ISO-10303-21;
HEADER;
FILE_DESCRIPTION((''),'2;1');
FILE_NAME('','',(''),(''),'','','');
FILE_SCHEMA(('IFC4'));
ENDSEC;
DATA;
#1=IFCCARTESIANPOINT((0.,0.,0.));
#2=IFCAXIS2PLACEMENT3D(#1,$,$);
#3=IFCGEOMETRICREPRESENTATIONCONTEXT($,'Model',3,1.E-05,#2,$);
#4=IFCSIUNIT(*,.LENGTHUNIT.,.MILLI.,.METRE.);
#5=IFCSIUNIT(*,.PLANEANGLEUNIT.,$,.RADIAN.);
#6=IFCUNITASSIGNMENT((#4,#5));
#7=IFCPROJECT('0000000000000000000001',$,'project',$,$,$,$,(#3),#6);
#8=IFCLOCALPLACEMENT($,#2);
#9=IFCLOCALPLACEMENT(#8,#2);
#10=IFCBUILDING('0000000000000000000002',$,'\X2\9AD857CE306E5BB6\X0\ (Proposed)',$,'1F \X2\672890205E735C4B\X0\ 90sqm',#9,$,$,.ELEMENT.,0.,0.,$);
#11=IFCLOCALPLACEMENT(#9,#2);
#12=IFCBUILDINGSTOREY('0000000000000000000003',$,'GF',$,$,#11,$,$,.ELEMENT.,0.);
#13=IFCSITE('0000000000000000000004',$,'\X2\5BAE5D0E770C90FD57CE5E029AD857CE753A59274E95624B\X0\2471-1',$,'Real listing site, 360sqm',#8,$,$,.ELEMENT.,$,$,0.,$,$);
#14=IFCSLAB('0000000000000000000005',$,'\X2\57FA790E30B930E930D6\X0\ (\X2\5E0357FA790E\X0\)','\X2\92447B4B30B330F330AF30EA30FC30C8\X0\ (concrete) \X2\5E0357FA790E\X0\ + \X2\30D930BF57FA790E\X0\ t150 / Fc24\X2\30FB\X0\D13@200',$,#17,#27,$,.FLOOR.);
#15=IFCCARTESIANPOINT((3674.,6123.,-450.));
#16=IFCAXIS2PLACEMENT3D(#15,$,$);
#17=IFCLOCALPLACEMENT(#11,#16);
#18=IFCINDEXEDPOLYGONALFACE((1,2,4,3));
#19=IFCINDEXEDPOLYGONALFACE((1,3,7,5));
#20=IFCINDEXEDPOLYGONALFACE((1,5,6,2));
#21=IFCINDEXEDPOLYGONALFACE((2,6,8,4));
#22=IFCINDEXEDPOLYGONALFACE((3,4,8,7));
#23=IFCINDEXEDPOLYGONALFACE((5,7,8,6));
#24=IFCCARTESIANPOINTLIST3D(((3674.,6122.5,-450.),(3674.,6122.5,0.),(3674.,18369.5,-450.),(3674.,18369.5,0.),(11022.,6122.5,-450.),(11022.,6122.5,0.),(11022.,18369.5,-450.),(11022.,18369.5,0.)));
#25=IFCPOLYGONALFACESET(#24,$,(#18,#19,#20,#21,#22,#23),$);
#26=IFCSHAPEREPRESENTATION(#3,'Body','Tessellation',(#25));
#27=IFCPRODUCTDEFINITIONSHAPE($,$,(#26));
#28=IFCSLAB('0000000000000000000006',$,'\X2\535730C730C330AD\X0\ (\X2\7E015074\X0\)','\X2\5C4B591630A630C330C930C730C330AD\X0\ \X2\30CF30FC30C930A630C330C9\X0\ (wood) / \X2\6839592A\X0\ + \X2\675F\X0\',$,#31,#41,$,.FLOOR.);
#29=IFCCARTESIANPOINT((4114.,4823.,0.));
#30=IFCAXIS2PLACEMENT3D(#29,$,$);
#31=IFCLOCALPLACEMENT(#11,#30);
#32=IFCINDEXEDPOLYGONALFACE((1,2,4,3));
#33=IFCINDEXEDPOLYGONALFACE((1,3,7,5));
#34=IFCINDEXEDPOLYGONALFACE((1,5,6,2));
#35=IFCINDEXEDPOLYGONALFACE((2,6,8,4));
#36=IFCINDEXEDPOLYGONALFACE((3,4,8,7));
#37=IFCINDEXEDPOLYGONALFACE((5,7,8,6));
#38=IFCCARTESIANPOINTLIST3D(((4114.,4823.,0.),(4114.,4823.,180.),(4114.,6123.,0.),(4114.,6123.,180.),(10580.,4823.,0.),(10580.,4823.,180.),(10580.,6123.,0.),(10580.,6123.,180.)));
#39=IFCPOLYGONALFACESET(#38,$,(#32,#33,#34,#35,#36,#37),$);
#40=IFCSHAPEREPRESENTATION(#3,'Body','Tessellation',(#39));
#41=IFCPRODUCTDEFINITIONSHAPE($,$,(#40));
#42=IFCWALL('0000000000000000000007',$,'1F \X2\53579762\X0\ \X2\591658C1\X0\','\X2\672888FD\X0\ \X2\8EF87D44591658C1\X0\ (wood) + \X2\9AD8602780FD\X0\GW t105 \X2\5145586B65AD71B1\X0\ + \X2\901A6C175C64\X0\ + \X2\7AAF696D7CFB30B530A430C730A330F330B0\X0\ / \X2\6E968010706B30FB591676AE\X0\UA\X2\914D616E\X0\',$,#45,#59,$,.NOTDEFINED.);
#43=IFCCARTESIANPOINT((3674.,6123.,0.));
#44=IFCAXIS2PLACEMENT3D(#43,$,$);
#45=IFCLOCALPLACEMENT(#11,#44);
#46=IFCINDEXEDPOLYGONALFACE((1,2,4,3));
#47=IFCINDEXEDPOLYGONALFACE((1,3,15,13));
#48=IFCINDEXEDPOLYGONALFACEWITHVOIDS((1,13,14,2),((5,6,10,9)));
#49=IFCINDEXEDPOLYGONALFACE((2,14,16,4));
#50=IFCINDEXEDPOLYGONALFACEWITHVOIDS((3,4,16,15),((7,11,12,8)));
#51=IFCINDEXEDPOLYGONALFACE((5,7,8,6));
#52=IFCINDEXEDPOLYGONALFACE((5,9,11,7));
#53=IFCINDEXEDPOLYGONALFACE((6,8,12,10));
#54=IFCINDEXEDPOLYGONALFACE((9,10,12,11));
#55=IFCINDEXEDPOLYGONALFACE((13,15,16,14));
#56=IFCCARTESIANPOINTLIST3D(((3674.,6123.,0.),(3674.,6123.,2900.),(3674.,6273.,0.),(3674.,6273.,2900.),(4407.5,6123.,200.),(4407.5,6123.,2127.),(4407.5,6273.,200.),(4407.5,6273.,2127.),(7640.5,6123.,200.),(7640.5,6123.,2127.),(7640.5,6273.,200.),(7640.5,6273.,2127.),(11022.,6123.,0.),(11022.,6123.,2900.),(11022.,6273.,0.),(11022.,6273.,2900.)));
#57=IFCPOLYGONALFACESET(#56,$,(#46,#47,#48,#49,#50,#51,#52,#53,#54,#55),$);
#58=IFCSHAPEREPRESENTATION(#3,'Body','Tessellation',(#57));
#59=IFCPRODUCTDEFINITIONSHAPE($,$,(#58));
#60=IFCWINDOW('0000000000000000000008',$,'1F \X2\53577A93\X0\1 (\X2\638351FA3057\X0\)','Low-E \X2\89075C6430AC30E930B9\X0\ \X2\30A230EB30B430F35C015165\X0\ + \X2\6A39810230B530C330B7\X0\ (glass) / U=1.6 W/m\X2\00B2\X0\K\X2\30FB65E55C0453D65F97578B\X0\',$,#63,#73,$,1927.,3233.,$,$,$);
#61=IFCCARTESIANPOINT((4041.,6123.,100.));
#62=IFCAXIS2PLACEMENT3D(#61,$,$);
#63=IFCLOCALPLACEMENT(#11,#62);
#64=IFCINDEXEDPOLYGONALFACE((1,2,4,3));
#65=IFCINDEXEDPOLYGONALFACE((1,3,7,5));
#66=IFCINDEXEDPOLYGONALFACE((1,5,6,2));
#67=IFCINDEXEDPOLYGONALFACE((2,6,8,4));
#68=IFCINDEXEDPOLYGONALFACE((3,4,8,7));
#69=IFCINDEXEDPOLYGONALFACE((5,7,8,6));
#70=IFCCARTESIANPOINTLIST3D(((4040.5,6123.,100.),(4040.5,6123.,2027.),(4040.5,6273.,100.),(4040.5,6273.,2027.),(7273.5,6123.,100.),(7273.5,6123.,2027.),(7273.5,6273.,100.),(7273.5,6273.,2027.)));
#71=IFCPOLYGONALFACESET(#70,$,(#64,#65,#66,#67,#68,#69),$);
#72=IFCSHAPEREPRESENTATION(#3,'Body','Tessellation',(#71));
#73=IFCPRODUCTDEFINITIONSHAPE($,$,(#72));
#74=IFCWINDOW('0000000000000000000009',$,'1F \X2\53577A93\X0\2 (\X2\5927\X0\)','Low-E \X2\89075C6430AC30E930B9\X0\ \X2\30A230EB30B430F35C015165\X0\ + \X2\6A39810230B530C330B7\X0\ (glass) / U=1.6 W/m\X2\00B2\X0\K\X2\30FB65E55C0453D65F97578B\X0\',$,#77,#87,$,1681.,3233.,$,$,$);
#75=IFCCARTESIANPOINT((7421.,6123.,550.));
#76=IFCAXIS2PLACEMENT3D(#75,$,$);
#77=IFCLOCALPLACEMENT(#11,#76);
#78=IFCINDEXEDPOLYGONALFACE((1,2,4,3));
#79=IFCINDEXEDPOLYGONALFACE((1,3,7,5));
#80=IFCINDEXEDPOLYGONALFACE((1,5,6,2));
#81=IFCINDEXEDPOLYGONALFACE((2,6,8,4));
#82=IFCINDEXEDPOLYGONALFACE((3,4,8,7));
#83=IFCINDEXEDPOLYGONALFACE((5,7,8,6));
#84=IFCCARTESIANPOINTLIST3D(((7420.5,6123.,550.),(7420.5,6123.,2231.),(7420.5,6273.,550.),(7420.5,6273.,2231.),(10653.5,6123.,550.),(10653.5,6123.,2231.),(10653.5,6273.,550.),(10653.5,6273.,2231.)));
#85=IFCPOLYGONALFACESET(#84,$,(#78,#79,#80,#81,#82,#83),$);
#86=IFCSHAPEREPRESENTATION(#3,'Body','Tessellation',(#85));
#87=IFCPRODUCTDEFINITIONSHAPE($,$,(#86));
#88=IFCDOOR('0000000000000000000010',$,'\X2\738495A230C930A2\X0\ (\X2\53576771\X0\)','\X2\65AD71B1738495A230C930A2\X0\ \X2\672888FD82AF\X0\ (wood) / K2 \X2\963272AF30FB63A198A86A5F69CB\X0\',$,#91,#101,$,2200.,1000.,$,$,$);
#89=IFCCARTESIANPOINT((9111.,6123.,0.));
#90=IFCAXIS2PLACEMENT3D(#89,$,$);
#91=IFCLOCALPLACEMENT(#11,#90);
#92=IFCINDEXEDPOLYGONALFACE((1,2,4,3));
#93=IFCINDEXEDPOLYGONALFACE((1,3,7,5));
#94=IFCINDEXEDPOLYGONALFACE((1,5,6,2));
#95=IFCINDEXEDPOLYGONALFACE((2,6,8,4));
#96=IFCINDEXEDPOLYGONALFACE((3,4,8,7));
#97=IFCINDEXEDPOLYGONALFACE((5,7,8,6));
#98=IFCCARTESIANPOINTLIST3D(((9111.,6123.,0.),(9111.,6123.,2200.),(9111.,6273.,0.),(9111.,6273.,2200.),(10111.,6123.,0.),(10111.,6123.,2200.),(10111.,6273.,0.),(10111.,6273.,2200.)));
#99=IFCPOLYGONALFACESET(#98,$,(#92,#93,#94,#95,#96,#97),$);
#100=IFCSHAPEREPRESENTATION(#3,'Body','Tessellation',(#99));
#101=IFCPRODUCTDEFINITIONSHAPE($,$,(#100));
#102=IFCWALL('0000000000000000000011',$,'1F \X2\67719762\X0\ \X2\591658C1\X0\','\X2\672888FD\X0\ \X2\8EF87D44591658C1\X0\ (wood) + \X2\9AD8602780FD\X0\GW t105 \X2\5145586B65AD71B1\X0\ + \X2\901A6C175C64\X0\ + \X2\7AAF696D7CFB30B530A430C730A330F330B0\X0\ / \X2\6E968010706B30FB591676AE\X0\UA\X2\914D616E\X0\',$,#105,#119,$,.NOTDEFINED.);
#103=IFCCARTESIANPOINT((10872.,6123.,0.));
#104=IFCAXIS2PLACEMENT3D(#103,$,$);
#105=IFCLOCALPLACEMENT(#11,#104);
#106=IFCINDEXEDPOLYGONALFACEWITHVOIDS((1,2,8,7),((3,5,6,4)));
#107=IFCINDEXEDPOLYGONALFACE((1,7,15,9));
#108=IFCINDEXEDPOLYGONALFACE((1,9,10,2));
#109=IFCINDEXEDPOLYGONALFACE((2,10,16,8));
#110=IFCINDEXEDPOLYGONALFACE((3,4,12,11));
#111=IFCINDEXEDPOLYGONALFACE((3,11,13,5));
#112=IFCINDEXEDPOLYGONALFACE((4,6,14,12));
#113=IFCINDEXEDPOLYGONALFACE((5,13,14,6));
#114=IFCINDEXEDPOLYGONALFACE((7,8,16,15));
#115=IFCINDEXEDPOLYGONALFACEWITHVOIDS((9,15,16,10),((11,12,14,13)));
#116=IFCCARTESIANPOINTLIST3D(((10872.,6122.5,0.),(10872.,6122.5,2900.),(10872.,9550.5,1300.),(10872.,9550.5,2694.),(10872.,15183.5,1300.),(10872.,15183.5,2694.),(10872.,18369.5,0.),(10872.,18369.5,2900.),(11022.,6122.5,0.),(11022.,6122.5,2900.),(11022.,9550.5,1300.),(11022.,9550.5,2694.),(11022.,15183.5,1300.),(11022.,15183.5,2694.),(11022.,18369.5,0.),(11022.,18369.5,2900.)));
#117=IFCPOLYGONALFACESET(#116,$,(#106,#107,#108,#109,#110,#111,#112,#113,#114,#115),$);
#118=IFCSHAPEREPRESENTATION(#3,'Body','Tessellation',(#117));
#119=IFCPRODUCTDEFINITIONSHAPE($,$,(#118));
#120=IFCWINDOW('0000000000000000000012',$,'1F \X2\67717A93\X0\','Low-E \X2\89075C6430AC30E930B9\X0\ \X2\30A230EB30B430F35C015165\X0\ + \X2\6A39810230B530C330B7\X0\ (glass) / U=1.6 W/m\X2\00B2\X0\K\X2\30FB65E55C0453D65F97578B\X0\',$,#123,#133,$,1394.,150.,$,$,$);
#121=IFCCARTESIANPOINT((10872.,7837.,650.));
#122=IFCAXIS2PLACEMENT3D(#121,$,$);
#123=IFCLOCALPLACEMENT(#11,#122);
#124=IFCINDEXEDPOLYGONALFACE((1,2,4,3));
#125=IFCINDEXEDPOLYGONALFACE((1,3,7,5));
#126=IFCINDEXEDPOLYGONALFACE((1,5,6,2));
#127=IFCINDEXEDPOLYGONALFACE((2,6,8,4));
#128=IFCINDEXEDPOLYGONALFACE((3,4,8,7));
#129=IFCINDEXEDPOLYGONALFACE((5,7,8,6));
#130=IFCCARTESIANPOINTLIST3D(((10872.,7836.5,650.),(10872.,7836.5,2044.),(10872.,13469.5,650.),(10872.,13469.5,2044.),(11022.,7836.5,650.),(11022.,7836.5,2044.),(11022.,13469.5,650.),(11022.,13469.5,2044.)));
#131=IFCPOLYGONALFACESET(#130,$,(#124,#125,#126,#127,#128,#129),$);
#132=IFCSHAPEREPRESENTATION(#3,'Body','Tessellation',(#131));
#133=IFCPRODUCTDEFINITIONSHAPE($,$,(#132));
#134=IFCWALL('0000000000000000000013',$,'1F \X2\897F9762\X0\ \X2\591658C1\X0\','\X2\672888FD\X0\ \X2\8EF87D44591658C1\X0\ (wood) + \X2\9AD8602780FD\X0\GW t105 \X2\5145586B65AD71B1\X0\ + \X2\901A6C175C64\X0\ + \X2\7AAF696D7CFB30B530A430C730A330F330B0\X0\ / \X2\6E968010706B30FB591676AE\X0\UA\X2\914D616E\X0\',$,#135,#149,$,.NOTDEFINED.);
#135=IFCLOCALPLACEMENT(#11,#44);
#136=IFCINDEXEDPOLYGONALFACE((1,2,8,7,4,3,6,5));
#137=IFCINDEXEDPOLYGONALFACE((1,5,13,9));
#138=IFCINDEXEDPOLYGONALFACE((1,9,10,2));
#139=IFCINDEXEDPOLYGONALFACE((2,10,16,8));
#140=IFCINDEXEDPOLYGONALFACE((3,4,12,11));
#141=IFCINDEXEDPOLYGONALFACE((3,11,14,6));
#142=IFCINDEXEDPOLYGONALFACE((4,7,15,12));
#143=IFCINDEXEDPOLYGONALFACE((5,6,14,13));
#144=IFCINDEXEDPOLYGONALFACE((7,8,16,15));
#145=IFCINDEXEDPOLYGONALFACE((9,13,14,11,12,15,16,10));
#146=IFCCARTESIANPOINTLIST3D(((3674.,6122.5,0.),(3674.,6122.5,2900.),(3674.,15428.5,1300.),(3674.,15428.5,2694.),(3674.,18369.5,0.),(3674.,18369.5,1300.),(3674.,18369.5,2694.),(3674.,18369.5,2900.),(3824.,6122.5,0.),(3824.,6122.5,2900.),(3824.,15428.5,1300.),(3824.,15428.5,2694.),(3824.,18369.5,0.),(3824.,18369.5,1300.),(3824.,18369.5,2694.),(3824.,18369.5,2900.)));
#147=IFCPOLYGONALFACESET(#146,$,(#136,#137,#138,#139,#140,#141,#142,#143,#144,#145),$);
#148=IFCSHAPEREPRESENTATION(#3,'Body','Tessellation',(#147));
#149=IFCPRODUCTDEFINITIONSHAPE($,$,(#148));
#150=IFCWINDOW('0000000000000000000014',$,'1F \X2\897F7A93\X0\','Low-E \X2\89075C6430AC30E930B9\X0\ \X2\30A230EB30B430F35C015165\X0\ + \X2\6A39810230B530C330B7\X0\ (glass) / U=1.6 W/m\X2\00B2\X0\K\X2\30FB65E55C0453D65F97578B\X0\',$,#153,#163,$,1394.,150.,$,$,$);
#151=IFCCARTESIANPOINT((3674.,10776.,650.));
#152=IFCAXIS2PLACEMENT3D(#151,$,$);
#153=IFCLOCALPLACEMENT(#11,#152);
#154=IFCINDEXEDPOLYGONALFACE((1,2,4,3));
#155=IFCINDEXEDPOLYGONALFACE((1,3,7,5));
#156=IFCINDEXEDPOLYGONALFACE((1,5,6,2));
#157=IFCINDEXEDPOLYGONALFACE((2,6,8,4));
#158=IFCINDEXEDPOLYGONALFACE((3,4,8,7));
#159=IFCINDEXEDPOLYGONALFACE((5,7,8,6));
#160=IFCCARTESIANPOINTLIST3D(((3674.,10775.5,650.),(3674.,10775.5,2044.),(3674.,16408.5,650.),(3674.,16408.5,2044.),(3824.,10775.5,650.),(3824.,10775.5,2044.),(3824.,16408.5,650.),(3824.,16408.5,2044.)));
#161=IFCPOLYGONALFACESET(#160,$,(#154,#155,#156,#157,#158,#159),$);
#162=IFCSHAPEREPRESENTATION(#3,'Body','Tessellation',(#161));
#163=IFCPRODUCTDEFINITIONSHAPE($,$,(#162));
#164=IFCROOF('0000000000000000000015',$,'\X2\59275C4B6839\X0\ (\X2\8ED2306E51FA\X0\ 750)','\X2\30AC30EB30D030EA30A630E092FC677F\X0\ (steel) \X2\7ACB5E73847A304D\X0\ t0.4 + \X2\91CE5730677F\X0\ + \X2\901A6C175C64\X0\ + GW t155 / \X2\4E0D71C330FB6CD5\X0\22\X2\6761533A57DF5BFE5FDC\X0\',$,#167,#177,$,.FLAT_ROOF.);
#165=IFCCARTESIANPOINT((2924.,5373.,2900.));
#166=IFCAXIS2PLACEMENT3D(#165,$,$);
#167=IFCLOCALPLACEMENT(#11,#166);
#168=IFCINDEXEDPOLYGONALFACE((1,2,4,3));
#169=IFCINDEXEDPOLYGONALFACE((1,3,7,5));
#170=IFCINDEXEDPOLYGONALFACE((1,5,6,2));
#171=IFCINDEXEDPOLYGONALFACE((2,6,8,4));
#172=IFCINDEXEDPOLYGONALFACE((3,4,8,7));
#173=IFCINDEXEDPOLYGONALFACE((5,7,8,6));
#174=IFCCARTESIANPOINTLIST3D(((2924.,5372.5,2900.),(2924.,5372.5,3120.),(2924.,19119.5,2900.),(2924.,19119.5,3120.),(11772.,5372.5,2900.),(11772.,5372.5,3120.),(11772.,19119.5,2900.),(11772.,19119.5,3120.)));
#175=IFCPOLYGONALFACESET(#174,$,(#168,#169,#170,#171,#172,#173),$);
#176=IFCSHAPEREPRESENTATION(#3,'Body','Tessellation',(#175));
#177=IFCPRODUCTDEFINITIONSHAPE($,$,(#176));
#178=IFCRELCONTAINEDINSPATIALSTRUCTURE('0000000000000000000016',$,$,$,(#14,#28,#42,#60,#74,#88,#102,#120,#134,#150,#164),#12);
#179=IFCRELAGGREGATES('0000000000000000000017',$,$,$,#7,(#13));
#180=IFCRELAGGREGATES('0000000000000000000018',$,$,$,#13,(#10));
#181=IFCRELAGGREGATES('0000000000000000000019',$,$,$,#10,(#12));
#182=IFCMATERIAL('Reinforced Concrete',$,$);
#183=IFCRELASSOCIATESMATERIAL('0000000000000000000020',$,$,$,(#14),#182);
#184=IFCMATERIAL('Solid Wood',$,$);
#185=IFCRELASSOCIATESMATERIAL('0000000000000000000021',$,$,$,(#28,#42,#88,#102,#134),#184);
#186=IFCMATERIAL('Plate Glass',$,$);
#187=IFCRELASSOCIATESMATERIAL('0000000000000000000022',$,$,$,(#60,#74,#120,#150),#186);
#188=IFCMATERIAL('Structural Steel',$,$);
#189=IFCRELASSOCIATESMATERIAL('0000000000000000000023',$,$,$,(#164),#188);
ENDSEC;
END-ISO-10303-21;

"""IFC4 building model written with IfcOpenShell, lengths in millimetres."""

from ifc_helpers import new_model, si_unit, frame, frame_2d, origin, place, context, project, spatial, rectangle, extrude, material, element, fill, save


model = new_model("IFC4")

# Units and contexts
model_context = context("Model", 3, precision=1e-05, world=origin())
ifc_project = project(units=[si_unit("LENGTHUNIT", "METRE", prefix="MILLI"), si_unit("PLANEANGLEUNIT", "RADIAN")], contexts=[model_context])

# Site, building, storey
site_placement = place(None, origin())
site = spatial("IfcSite", under=ifc_project, at=site_placement, Name="宮崎県都城市高城町大井手2471-1", ObjectType="Real listing site, 360sqm", CompositionType="ELEMENT", RefElevation=0.0)
building_placement = place(site_placement, origin())
building = spatial("IfcBuilding", under=site, at=building_placement, Name="高城の家 (Proposed)", ObjectType="1F 木造平屋 90sqm", CompositionType="ELEMENT", ElevationOfRefHeight=0.0, ElevationOfTerrain=0.0)
storey_placement = place(building_placement, origin())
storey = spatial("IfcBuildingStorey", under=building, at=storey_placement, Name="GF", CompositionType="ELEMENT", Elevation=0.0)

# Slabs
ifc_material_1 = material(Name="Reinforced Concrete")
slab_1_placement = place(storey_placement, frame((3674.0, 6123.0, -450.0)))
element("IfcSlab", 1, at=slab_1_placement, inside=storey, material=ifc_material_1, Name="基礎スラブ (布基礎)", Description="鉄筋コンクリート (concrete) 布基礎 + ベタ基礎 t150 / Fc24・D13@200", PredefinedType="FLOOR", context=model_context, shape_type="SweptSolid", body=[
    extrude(rectangle(XDim=7348.0, YDim=12247.0, at=frame_2d((3674.0, 6123.0))), frame((3674.0, 6123.0, -450.0)), (0.0, 0.0, 1.0), 450.0),
])
ifc_material_2 = material(Name="Solid Wood")
slab_2_placement = place(storey_placement, frame((4114.0, 4823.0, 0.0)))
element("IfcSlab", 2, at=slab_2_placement, inside=storey, material=ifc_material_2, Name="南デッキ (縁側)", Description="屋外ウッドデッキ ハードウッド (wood) / 根太 + 束", PredefinedType="FLOOR", context=model_context, shape_type="SweptSolid", body=[
    extrude(rectangle(XDim=6466.0, YDim=1300.0, at=frame_2d((3233.0, 650.0))), frame((4114.0, 4823.0, 0.0)), (0.0, 0.0, 1.0), 180.0),
])

# Wall, openings, windows, door
wall_1_placement = place(storey_placement, frame((3674.0, 6123.0, 0.0)))
wall_1 = element("IfcWall", 3, at=wall_1_placement, inside=storey, material=ifc_material_2, Name="1F 南面 外壁", Description="木製 軸組外壁 (wood) + 高性能GW t105 充填断熱 + 通気層 + 窯業系サイディング / 準耐火・外皮UA配慮", PredefinedType="NOTDEFINED", context=model_context, shape_type="SweptSolid", body=[
    extrude(rectangle(XDim=7348.0, YDim=150.0, at=frame_2d((3674.0, 75.0))), frame((3674.0, 6123.0, 0.0)), (0.0, 0.0, 1.0), 2900.0),
])
opening_1_placement = place(storey_placement, frame((4041.0, 6123.0, 100.0)))
opening_1 = element("IfcOpeningElement", 4, at=opening_1_placement, cuts=wall_1, PredefinedType="NOTDEFINED", context=model_context, shape_type="SweptSolid", body=[
    extrude(rectangle(XDim=3233.0, YDim=150.0, at=frame_2d((1616.0, 75.0))), frame((4041.0, 6123.0, 100.0)), (0.0, 0.0, 1.0), 1927.0),
])
opening_2_placement = place(storey_placement, frame((7421.0, 6123.0, 550.0)))
opening_2 = element("IfcOpeningElement", 5, at=opening_2_placement, cuts=wall_1, PredefinedType="NOTDEFINED", context=model_context, shape_type="SweptSolid", body=[
    extrude(rectangle(XDim=3233.0, YDim=150.0, at=frame_2d((1616.0, 75.0))), frame((7421.0, 6123.0, 550.0)), (0.0, 0.0, 1.0), 1681.0),
])
opening_3_placement = place(storey_placement, frame((9111.0, 6123.0, 0.0)))
opening_3 = element("IfcOpeningElement", 6, at=opening_3_placement, cuts=wall_1, PredefinedType="NOTDEFINED", context=model_context, shape_type="SweptSolid", body=[
    extrude(rectangle(XDim=1000.0, YDim=150.0, at=frame_2d((500.0, 75.0))), frame((9111.0, 6123.0, 0.0)), (0.0, 0.0, 1.0), 2200.0),
])
ifc_material_3 = material(Name="Plate Glass")
window_1_placement = place(storey_placement, frame((4041.0, 6123.0, 100.0)))
window_1 = element("IfcWindow", 7, at=window_1_placement, inside=storey, material=ifc_material_3, Name="1F 南窓1 (掃出し)", Description="Low-E 複層ガラス アルゴン封入 + 樹脂サッシ (glass) / U=1.6 W/m²K・日射取得型", OverallHeight=1927.0, OverallWidth=3233.0, context=model_context, shape_type="SweptSolid", body=[
    extrude(rectangle(XDim=3233.0, YDim=150.0, at=frame_2d((1616.0, 75.0))), frame((4041.0, 6123.0, 100.0)), (0.0, 0.0, 1.0), 1927.0),
])
fill(opening_1, window_1)
window_2_placement = place(storey_placement, frame((7421.0, 6123.0, 550.0)))
window_2 = element("IfcWindow", 8, at=window_2_placement, inside=storey, material=ifc_material_3, Name="1F 南窓2 (大)", Description="Low-E 複層ガラス アルゴン封入 + 樹脂サッシ (glass) / U=1.6 W/m²K・日射取得型", OverallHeight=1681.0, OverallWidth=3233.0, context=model_context, shape_type="SweptSolid", body=[
    extrude(rectangle(XDim=3233.0, YDim=150.0, at=frame_2d((1616.0, 75.0))), frame((7421.0, 6123.0, 550.0)), (0.0, 0.0, 1.0), 1681.0),
])
fill(opening_2, window_2)
door_placement = place(storey_placement, frame((9111.0, 6123.0, 0.0)))
door = element("IfcDoor", 9, at=door_placement, inside=storey, material=ifc_material_2, Name="玄関ドア (南東)", Description="断熱玄関ドア 木製芯 (wood) / K2 防犯・採風機構", OverallHeight=2200.0, OverallWidth=1000.0, context=model_context, shape_type="SweptSolid", body=[
    extrude(rectangle(XDim=1000.0, YDim=150.0, at=frame_2d((500.0, 75.0))), frame((9111.0, 6123.0, 0.0)), (0.0, 0.0, 1.0), 2200.0),
])
fill(opening_3, door)

# Walls, openings, windows
wall_2_placement = place(storey_placement, frame((10872.0, 6123.0, 0.0)))
wall_2 = element("IfcWall", 10, at=wall_2_placement, inside=storey, material=ifc_material_2, Name="1F 東面 外壁", Description="木製 軸組外壁 (wood) + 高性能GW t105 充填断熱 + 通気層 + 窯業系サイディング / 準耐火・外皮UA配慮", PredefinedType="NOTDEFINED", context=model_context, shape_type="SweptSolid", body=[
    extrude(rectangle(XDim=150.0, YDim=12247.0, at=frame_2d((75.0, 6123.0))), frame((10872.0, 6123.0, 0.0)), (0.0, 0.0, 1.0), 2900.0),
])
opening_4_placement = place(storey_placement, frame((10872.0, 7837.0, 650.0)))
opening_4 = element("IfcOpeningElement", 11, at=opening_4_placement, cuts=wall_2, PredefinedType="NOTDEFINED", context=model_context, shape_type="SweptSolid", body=[
    extrude(rectangle(XDim=150.0, YDim=5633.0, at=frame_2d((75.0, 2816.0))), frame((10872.0, 7837.0, 650.0)), (0.0, 0.0, 1.0), 1394.0),
])
window_3_placement = place(storey_placement, frame((10872.0, 7837.0, 650.0)))
window_3 = element("IfcWindow", 12, at=window_3_placement, inside=storey, material=ifc_material_3, Name="1F 東窓", Description="Low-E 複層ガラス アルゴン封入 + 樹脂サッシ (glass) / U=1.6 W/m²K・日射取得型", OverallHeight=1394.0, OverallWidth=150.0, context=model_context, shape_type="SweptSolid", body=[
    extrude(rectangle(XDim=150.0, YDim=5633.0, at=frame_2d((75.0, 2816.0))), frame((10872.0, 7837.0, 650.0)), (0.0, 0.0, 1.0), 1394.0),
])
fill(opening_4, window_3)
wall_3_placement = place(storey_placement, frame((3674.0, 6123.0, 0.0)))
wall_3 = element("IfcWall", 13, at=wall_3_placement, inside=storey, material=ifc_material_2, Name="1F 西面 外壁", Description="木製 軸組外壁 (wood) + 高性能GW t105 充填断熱 + 通気層 + 窯業系サイディング / 準耐火・外皮UA配慮", PredefinedType="NOTDEFINED", context=model_context, shape_type="SweptSolid", body=[
    extrude(rectangle(XDim=150.0, YDim=12247.0, at=frame_2d((75.0, 6123.0))), frame((3674.0, 6123.0, 0.0)), (0.0, 0.0, 1.0), 2900.0),
])
opening_5_placement = place(storey_placement, frame((3674.0, 10776.0, 650.0)))
opening_5 = element("IfcOpeningElement", 14, at=opening_5_placement, cuts=wall_3, PredefinedType="NOTDEFINED", context=model_context, shape_type="SweptSolid", body=[
    extrude(rectangle(XDim=150.0, YDim=5633.0, at=frame_2d((75.0, 2816.0))), frame((3674.0, 10776.0, 650.0)), (0.0, 0.0, 1.0), 1394.0),
])
window_4_placement = place(storey_placement, frame((3674.0, 10776.0, 650.0)))
window_4 = element("IfcWindow", 15, at=window_4_placement, inside=storey, material=ifc_material_3, Name="1F 西窓", Description="Low-E 複層ガラス アルゴン封入 + 樹脂サッシ (glass) / U=1.6 W/m²K・日射取得型", OverallHeight=1394.0, OverallWidth=150.0, context=model_context, shape_type="SweptSolid", body=[
    extrude(rectangle(XDim=150.0, YDim=5633.0, at=frame_2d((75.0, 2816.0))), frame((3674.0, 10776.0, 650.0)), (0.0, 0.0, 1.0), 1394.0),
])
fill(opening_5, window_4)

# Roof
ifc_material_4 = material(Name="Structural Steel")
roof_placement = place(storey_placement, frame((2924.0, 5373.0, 2900.0)))
element("IfcRoof", 16, at=roof_placement, inside=storey, material=ifc_material_4, Name="大屋根 (軒の出 750)", Description="ガルバリウム鋼板 (steel) 立平葺き t0.4 + 野地板 + 通気層 + GW t155 / 不燃・法22条区域対応", PredefinedType="FLAT_ROOF", context=model_context, shape_type="SweptSolid", body=[
    extrude(rectangle(XDim=8848.0, YDim=13747.0, at=frame_2d((4424.0, 6873.0))), frame((2924.0, 5373.0, 2900.0)), (0.0, 0.0, 1.0), 220.0),
])

save(model, "model.ifc")
